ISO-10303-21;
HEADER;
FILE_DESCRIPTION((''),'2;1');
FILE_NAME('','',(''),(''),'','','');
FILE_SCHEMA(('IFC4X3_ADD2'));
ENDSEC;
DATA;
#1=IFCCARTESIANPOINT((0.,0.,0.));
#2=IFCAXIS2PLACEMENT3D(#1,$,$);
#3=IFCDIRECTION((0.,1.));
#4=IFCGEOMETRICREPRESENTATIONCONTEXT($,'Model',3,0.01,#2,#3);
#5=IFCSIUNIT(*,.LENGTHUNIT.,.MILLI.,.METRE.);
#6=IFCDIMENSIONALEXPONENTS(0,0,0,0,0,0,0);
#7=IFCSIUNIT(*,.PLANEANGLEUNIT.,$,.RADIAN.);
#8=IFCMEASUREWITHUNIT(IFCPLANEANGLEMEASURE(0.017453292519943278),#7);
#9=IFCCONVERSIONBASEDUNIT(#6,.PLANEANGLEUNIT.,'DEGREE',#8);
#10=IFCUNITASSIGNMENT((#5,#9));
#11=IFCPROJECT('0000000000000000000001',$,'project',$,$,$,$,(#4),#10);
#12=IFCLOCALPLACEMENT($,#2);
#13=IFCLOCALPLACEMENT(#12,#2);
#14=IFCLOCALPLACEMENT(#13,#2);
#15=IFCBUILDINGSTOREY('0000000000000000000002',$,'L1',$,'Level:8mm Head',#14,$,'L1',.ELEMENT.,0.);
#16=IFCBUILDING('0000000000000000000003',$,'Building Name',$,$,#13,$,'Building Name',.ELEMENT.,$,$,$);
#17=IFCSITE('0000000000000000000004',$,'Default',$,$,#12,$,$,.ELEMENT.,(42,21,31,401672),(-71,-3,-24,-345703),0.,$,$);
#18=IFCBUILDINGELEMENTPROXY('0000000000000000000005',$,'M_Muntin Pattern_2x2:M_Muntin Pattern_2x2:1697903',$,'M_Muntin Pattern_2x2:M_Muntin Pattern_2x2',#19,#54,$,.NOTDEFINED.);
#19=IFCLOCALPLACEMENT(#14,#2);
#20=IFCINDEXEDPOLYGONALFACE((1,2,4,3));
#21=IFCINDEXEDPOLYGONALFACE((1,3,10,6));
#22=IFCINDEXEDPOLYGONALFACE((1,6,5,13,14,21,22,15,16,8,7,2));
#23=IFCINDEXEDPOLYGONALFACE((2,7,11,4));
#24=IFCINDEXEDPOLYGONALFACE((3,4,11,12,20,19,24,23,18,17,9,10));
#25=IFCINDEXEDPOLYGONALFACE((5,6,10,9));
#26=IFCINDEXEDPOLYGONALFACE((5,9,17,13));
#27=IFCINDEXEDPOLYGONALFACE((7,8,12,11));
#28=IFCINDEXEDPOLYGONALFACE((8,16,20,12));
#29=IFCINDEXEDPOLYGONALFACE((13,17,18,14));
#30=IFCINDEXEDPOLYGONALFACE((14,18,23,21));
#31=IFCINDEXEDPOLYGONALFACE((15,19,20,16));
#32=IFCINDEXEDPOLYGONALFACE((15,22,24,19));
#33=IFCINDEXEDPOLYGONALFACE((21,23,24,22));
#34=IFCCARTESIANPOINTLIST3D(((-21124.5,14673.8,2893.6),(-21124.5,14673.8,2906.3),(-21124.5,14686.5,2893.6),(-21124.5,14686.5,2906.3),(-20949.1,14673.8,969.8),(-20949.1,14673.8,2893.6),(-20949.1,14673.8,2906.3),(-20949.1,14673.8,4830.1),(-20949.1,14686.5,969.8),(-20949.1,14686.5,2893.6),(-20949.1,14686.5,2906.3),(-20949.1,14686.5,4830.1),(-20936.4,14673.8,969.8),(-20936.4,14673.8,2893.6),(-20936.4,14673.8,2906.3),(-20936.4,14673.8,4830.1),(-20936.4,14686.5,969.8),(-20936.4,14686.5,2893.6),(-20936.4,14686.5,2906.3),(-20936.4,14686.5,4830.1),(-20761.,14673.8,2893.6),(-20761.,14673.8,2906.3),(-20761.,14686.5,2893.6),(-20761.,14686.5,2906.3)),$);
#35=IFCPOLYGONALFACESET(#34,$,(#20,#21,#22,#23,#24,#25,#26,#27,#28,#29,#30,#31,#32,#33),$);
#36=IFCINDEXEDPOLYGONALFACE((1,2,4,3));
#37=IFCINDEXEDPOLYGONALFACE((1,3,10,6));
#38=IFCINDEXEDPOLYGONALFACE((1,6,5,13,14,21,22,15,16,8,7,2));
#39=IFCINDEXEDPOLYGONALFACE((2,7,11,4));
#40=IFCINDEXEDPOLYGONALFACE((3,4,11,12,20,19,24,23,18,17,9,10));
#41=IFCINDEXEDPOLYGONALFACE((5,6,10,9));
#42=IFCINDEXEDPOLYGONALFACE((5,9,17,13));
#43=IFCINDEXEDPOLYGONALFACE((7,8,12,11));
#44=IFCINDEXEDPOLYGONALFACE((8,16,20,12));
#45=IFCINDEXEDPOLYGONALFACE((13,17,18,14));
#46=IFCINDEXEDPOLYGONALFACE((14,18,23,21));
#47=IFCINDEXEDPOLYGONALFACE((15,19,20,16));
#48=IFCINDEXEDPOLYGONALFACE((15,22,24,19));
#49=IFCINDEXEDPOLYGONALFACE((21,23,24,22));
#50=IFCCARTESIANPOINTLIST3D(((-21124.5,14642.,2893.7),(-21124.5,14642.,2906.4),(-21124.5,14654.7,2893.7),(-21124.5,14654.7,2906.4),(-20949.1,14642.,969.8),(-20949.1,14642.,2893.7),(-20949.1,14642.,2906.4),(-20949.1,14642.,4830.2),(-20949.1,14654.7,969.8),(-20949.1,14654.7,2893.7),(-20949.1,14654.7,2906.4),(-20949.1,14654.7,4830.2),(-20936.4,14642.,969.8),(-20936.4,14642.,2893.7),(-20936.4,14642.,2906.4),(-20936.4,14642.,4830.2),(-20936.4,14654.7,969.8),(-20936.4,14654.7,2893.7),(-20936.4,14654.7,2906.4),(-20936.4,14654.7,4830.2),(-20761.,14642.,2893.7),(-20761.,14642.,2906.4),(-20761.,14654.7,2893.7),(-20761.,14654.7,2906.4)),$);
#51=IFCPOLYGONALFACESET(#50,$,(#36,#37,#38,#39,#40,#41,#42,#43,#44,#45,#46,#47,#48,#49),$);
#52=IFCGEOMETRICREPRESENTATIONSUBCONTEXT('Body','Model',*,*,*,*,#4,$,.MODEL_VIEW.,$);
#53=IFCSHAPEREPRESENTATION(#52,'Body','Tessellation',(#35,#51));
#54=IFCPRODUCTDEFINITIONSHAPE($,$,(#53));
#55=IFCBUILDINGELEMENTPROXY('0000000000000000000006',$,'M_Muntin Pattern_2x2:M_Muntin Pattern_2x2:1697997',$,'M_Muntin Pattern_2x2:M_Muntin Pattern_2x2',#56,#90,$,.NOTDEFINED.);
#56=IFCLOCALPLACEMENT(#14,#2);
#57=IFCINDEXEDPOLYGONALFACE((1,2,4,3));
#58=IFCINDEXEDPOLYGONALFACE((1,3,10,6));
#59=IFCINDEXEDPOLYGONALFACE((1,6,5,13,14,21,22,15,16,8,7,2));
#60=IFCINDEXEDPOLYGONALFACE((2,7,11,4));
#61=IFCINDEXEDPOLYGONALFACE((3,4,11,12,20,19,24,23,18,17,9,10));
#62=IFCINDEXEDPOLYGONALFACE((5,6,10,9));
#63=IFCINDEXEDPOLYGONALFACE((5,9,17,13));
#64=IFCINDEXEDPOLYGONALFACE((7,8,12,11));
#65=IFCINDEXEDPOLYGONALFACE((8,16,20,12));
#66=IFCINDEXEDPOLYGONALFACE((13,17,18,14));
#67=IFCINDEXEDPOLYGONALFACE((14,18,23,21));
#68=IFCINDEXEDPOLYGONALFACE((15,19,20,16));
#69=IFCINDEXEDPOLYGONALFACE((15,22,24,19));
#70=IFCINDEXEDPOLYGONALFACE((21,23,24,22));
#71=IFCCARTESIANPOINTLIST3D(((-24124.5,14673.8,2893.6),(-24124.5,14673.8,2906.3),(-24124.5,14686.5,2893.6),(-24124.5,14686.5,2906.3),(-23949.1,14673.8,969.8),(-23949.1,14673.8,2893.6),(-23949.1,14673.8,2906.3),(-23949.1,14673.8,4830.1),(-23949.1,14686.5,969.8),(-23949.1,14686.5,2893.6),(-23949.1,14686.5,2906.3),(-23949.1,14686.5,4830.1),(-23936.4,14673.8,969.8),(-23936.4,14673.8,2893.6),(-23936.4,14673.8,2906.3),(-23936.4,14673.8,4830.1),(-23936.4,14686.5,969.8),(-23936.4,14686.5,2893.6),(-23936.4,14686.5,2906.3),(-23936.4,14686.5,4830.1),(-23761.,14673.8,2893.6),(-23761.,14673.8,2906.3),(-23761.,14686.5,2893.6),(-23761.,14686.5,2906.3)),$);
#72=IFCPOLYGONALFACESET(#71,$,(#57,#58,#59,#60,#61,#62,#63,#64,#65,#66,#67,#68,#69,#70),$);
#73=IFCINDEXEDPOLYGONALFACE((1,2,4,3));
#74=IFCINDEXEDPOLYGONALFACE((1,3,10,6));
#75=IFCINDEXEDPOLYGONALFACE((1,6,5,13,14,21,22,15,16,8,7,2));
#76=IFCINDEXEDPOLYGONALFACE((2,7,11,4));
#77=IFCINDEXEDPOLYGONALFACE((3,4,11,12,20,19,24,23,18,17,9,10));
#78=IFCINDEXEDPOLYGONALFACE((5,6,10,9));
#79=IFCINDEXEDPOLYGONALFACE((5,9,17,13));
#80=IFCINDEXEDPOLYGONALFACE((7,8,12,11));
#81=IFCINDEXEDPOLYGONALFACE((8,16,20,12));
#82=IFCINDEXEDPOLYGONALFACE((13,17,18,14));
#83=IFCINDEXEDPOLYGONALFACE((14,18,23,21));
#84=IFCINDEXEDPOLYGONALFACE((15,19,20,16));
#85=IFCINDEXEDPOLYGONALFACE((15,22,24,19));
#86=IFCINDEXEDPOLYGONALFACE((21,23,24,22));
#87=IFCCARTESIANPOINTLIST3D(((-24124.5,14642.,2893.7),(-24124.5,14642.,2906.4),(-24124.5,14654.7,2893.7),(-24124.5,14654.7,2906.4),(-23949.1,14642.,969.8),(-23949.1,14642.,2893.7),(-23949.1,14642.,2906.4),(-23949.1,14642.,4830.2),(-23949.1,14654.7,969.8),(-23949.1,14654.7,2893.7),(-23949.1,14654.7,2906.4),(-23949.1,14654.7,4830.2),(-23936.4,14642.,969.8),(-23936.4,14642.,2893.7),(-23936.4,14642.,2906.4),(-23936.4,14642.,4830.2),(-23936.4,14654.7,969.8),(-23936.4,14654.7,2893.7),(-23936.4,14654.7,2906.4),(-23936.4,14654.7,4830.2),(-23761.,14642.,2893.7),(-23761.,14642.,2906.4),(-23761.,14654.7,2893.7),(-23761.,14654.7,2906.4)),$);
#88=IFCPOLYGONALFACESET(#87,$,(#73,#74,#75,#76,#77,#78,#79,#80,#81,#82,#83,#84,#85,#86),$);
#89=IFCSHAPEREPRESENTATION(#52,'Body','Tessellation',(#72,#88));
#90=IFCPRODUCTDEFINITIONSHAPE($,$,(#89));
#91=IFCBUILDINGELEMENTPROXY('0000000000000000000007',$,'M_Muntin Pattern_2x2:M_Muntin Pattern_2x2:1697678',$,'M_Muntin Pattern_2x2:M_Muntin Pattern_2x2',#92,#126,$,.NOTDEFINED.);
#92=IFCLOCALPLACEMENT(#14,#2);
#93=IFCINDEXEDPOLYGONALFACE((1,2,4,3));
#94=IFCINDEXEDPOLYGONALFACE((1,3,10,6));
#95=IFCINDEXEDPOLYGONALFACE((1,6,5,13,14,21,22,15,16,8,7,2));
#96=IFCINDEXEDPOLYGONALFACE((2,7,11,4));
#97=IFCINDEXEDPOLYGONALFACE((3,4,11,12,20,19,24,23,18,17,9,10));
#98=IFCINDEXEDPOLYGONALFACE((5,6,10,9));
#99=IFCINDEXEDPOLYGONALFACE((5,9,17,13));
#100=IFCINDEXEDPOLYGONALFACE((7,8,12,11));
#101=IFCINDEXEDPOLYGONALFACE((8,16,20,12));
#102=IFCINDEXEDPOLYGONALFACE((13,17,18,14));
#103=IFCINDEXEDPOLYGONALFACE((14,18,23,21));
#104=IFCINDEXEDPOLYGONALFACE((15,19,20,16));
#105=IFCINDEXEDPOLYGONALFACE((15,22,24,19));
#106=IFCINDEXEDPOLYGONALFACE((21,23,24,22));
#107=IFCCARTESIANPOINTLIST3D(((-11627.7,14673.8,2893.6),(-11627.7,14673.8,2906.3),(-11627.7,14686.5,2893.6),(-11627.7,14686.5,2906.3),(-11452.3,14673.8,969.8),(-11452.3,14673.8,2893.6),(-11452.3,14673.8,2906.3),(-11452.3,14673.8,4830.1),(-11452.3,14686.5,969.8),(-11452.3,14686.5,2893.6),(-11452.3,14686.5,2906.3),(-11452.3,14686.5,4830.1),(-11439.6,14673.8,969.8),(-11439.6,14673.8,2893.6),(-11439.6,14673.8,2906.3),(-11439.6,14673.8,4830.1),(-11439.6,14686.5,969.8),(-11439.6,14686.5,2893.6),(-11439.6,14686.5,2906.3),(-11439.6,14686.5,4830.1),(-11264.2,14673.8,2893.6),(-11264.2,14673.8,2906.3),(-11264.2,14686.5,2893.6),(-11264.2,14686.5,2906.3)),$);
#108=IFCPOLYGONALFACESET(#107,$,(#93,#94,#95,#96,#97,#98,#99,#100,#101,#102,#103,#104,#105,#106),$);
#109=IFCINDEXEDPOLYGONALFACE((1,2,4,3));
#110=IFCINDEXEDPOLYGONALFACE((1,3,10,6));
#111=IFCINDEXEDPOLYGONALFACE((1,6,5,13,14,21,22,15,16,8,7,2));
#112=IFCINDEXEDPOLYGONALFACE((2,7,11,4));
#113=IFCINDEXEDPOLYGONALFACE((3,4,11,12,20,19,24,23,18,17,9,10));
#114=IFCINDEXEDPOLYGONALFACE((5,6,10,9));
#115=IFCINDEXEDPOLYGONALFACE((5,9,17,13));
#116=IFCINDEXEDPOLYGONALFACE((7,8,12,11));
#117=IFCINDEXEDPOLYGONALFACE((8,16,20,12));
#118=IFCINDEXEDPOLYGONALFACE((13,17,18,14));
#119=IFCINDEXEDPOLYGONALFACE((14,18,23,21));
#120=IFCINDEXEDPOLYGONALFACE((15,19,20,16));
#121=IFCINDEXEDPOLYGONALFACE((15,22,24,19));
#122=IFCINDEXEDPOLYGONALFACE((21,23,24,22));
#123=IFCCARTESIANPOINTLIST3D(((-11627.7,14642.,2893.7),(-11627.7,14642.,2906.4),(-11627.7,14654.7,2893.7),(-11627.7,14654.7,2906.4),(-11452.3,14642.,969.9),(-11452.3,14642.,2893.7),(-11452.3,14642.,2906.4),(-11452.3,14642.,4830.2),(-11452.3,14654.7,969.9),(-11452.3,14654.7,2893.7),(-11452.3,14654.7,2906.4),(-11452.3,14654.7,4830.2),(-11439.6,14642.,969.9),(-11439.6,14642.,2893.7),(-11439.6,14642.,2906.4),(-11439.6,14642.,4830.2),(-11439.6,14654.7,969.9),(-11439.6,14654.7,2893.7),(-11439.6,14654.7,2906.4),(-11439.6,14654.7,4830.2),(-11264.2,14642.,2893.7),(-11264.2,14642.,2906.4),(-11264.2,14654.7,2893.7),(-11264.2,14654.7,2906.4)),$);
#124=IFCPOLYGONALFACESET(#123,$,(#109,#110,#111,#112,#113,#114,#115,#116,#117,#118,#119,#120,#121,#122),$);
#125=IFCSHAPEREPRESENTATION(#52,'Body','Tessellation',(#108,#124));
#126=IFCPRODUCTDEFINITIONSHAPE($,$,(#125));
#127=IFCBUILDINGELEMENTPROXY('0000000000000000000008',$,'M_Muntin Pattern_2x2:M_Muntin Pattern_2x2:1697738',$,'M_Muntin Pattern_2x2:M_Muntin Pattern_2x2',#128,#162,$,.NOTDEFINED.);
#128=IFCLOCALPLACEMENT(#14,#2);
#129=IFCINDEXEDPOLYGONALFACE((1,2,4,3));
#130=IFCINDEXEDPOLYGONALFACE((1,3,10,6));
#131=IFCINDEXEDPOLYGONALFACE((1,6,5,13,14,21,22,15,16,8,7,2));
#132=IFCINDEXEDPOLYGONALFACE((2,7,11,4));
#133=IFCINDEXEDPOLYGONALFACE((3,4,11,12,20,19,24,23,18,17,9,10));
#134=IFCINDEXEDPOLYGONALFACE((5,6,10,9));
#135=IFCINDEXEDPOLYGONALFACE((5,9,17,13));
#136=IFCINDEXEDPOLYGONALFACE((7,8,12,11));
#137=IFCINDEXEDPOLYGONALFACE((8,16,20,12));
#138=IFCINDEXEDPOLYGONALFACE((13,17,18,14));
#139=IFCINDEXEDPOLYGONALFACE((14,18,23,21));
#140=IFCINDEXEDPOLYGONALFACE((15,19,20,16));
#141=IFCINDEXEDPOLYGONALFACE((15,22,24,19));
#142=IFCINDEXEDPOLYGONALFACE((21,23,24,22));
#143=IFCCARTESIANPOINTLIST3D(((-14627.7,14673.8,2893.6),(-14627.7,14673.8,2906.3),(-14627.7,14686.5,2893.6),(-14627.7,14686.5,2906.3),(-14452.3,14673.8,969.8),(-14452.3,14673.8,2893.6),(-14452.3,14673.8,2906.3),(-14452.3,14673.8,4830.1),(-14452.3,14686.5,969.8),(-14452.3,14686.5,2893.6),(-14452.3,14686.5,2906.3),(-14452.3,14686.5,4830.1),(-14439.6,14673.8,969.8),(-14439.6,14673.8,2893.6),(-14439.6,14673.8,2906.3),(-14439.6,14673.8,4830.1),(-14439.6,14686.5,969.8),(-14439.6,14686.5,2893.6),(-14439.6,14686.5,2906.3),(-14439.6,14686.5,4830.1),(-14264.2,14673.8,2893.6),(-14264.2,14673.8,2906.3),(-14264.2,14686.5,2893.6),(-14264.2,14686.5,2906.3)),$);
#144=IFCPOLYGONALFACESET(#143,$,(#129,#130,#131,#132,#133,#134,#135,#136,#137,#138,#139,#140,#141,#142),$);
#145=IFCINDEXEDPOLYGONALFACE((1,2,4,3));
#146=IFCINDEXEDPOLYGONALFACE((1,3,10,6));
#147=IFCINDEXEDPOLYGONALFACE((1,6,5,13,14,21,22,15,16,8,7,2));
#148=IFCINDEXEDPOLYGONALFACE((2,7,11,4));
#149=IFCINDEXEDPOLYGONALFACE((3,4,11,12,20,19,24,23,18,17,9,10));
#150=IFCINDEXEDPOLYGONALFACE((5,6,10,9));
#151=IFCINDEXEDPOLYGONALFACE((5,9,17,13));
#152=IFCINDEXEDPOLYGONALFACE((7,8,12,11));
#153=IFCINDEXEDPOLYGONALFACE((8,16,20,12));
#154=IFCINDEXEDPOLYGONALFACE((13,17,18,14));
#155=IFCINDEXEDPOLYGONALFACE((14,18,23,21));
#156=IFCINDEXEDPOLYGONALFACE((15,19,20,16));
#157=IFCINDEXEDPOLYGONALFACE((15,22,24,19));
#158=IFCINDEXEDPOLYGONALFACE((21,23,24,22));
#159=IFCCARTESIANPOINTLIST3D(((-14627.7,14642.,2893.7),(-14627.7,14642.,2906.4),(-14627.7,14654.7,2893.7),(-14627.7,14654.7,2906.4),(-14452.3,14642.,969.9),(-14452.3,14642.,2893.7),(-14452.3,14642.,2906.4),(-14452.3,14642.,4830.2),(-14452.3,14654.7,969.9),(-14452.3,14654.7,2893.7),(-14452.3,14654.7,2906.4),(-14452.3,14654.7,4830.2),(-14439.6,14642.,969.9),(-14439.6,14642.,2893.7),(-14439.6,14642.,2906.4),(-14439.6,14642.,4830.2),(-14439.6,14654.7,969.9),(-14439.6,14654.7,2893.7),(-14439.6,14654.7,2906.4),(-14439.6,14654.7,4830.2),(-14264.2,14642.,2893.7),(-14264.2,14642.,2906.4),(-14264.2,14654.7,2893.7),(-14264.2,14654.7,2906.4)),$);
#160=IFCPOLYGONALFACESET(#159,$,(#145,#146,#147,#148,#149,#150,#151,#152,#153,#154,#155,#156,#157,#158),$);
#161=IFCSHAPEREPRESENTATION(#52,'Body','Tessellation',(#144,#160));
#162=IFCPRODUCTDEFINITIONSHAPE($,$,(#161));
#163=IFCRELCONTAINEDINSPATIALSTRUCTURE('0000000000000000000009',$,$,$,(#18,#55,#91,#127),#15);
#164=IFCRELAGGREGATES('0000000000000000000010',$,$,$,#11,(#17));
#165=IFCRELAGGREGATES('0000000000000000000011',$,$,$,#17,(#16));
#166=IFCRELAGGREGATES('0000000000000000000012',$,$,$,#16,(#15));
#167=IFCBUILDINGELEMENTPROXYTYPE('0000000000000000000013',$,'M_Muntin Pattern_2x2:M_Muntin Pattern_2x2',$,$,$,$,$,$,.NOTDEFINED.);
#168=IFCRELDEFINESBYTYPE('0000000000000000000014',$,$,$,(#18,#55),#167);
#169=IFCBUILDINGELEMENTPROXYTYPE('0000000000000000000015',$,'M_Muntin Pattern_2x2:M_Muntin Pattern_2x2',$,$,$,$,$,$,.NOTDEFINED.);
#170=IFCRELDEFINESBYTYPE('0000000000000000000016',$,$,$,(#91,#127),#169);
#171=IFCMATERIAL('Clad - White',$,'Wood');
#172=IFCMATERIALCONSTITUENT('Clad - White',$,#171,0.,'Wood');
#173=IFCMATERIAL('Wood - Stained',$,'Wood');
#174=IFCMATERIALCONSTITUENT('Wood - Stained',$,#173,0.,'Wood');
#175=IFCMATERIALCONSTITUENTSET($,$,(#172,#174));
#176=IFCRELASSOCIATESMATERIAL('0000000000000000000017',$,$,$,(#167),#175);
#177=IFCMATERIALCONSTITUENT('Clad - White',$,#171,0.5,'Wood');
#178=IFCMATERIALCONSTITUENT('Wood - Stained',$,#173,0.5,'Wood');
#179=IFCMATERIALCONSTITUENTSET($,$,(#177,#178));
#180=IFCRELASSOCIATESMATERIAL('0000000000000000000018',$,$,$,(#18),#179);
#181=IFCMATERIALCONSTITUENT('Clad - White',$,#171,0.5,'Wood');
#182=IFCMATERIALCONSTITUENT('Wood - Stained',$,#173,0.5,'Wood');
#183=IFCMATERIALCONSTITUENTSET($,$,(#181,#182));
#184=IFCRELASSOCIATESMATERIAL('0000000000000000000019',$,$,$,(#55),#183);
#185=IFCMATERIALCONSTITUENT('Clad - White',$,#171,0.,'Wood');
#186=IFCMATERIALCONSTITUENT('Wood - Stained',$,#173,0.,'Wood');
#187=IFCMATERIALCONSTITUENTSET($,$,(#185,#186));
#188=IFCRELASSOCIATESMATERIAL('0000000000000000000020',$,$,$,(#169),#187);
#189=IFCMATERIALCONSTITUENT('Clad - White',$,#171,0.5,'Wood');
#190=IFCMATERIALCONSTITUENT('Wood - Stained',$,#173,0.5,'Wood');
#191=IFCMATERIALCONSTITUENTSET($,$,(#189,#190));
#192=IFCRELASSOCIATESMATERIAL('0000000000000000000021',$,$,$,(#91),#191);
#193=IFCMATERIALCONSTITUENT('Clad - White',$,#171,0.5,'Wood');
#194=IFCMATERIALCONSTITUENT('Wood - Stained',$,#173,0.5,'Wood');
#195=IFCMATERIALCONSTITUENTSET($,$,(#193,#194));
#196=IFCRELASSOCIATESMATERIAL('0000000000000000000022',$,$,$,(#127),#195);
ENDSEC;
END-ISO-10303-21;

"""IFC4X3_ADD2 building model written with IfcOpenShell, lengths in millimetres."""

from ifc_helpers import new_model, entity, si_unit, converted_unit, direction, frame, origin, place, context, subcontext, project, spatial, polyline, outline, extrude, source, transform, mapped, material, constituent, constituent_set, type_object, type_shapes, element, save


model = new_model("IFC4X3_ADD2")

# Units and contexts
model_context = context("Model", 3, precision=0.01, world=origin(), true_north=direction((0.0, 1.0)))
body_context = subcontext(model_context, "Body", "Model", "MODEL_VIEW")
ifc_project = project(units=[si_unit("LENGTHUNIT", "METRE", prefix="MILLI"), converted_unit("PLANEANGLEUNIT", "DEGREE", entity("IfcPlaneAngleMeasure", 0.017453292519943278), si_unit("PLANEANGLEUNIT", "RADIAN"), dimensions=[0, 0, 0, 0, 0, 0, 0])], contexts=[model_context])

# Site, building, storey
site_placement = place(None, origin())
site = spatial("IfcSite", under=ifc_project, at=site_placement, Name="Default", CompositionType="ELEMENT", RefLatitude=(42, 21, 31, 401672), RefLongitude=(-71, -3, -24, -345703), RefElevation=0.0)
building_placement = place(site_placement, origin())
building = spatial("IfcBuilding", under=site, at=building_placement, Name="Building Name", LongName="Building Name", CompositionType="ELEMENT")
storey_placement = place(building_placement, origin())
storey = spatial("IfcBuildingStorey", under=building, at=storey_placement, Name="L1", ObjectType="Level:8mm Head", LongName="L1", CompositionType="ELEMENT", Elevation=0.0)

# Building element proxies
ifc_material_1 = material(Name="Clad - White", Category="Wood")
ifc_material_2 = material(Name="Wood - Stained", Category="Wood")
ifc_constituent_1 = constituent(ifc_material_1, Name="Clad - White", Category="Wood", fraction=0.0)
ifc_constituent_2 = constituent(ifc_material_2, Name="Wood - Stained", Category="Wood", fraction=0.0)
ifc_constituent_set_1 = constituent_set(constituents=[ifc_constituent_1, ifc_constituent_2])
building_element_proxy_type_1 = type_object("IfcBuildingElementProxyType", Name="M_Muntin Pattern_2x2:M_Muntin Pattern_2x2", PredefinedType="NOTDEFINED", material=ifc_constituent_set_1)
shared_shape_1 = source(origin(), body_context, "Body", "SweptSolid", [
    extrude(outline(polyline([(6.4, -6.4), (1930.1, -6.4), (1930.1, 6.3), (6.4, 6.3), (6.4, 181.7), (-6.3, 181.7), (-6.3, 6.3), (-1930.2, 6.3), (-1930.2, -6.4), (-6.3, -6.4), (-6.3, -181.7), (6.4, -181.7), (6.4, -6.4)])), frame((0.0, 9.5, 1930.1), z_axis=(0.0, 1.0, 0.0), x_axis=(0.0, 0.0, 1.0)), (0.0, 0.0, 1.0), 12.7),
    extrude(outline(polyline([(6.4, -6.4), (1930.2, -6.4), (1930.2, 6.3), (6.4, 6.3), (6.4, 181.7), (-6.3, 181.7), (-6.3, 6.3), (-1930.2, 6.3), (-1930.2, -6.4), (-6.3, -6.4), (-6.3, -181.7), (6.4, -181.7), (6.4, -6.4)])), frame((0.0, -22.2, 1930.2), z_axis=(0.0, 1.0, 0.0), x_axis=(0.0, 0.0, 1.0)), (0.0, 0.0, 1.0), 12.7),
])
type_shapes(building_element_proxy_type_1, [shared_shape_1])
ifc_constituent_3 = constituent(ifc_material_1, Name="Clad - White", Category="Wood", fraction=0.5)
ifc_constituent_4 = constituent(ifc_material_2, Name="Wood - Stained", Category="Wood", fraction=0.5)
ifc_constituent_set_2 = constituent_set(constituents=[ifc_constituent_3, ifc_constituent_4])
proxy_1_placement = place(storey_placement, frame((-20942.8, 14664.3, 969.8)))
element("IfcBuildingElementProxy", 1, at=proxy_1_placement, inside=storey, type_object=building_element_proxy_type_1, material=ifc_constituent_set_2, Name="M_Muntin Pattern_2x2:M_Muntin Pattern_2x2:1697903", ObjectType="M_Muntin Pattern_2x2:M_Muntin Pattern_2x2", PredefinedType="NOTDEFINED", context=body_context, shape_type="MappedRepresentation", body=[
    mapped(shared_shape_1, transform((0.0, 0.0, 0.0), scale=1.0)),
])
ifc_constituent_5 = constituent(ifc_material_1, Name="Clad - White", Category="Wood", fraction=0.5)
ifc_constituent_6 = constituent(ifc_material_2, Name="Wood - Stained", Category="Wood", fraction=0.5)
ifc_constituent_set_3 = constituent_set(constituents=[ifc_constituent_5, ifc_constituent_6])
proxy_2_placement = place(storey_placement, frame((-23942.8, 14664.3, 969.8)))
element("IfcBuildingElementProxy", 2, at=proxy_2_placement, inside=storey, type_object=building_element_proxy_type_1, material=ifc_constituent_set_3, Name="M_Muntin Pattern_2x2:M_Muntin Pattern_2x2:1697997", ObjectType="M_Muntin Pattern_2x2:M_Muntin Pattern_2x2", PredefinedType="NOTDEFINED", context=body_context, shape_type="MappedRepresentation", body=[
    mapped(shared_shape_1, transform((0.0, 0.0, 0.0), scale=1.0)),
])
ifc_constituent_7 = constituent(ifc_material_1, Name="Clad - White", Category="Wood", fraction=0.5)
ifc_constituent_8 = constituent(ifc_material_2, Name="Wood - Stained", Category="Wood", fraction=0.5)
ifc_constituent_set_4 = constituent_set(constituents=[ifc_constituent_7, ifc_constituent_8])
ifc_constituent_9 = constituent(ifc_material_1, Name="Clad - White", Category="Wood", fraction=0.0)
ifc_constituent_10 = constituent(ifc_material_2, Name="Wood - Stained", Category="Wood", fraction=0.0)
ifc_constituent_set_5 = constituent_set(constituents=[ifc_constituent_9, ifc_constituent_10])
building_element_proxy_type_2 = type_object("IfcBuildingElementProxyType", Name="M_Muntin Pattern_2x2:M_Muntin Pattern_2x2", PredefinedType="NOTDEFINED", material=ifc_constituent_set_5)
shared_shape_2 = source(origin(), body_context, "Body", "SweptSolid", [
    extrude(outline(polyline([(6.4, -6.4), (1930.1, -6.4), (1930.1, 6.3), (6.4, 6.3), (6.4, 181.7), (-6.3, 181.7), (-6.3, 6.3), (-1930.2, 6.3), (-1930.2, -6.4), (-6.3, -6.4), (-6.3, -181.7), (6.4, -181.7), (6.4, -6.4)])), frame((0.0, -22.2, 1930.1), z_axis=(0.0, 1.0, 0.0), x_axis=(0.0, 0.0, 1.0)), (0.0, 0.0, 1.0), 12.7),
    extrude(outline(polyline([(6.4, -6.4), (1930.2, -6.4), (1930.2, 6.3), (6.4, 6.3), (6.4, 181.7), (-6.3, 181.7), (-6.3, 6.3), (-1930.2, 6.3), (-1930.2, -6.4), (-6.3, -6.4), (-6.3, -181.7), (6.4, -181.7), (6.4, -6.4)])), frame((0.0, 9.5, 1930.2), z_axis=(0.0, 1.0, 0.0), x_axis=(0.0, 0.0, 1.0)), (0.0, 0.0, 1.0), 12.7),
])
type_shapes(building_element_proxy_type_2, [shared_shape_2])
proxy_3_placement = place(storey_placement, frame((-11445.9, 14664.3, 969.9), z_axis=(0.0, 0.0, 1.0), x_axis=(-1.0, 0.0, 0.0)))
element("IfcBuildingElementProxy", 3, at=proxy_3_placement, inside=storey, type_object=building_element_proxy_type_2, material=ifc_constituent_set_4, Name="M_Muntin Pattern_2x2:M_Muntin Pattern_2x2:1697678", ObjectType="M_Muntin Pattern_2x2:M_Muntin Pattern_2x2", PredefinedType="NOTDEFINED", context=body_context, shape_type="MappedRepresentation", body=[
    mapped(shared_shape_2, transform((0.0, 0.0, 0.0), scale=1.0)),
])
ifc_constituent_11 = constituent(ifc_material_1, Name="Clad - White", Category="Wood", fraction=0.5)
ifc_constituent_12 = constituent(ifc_material_2, Name="Wood - Stained", Category="Wood", fraction=0.5)
ifc_constituent_set_6 = constituent_set(constituents=[ifc_constituent_11, ifc_constituent_12])
proxy_4_placement = place(storey_placement, frame((-14445.9, 14664.3, 969.9), z_axis=(0.0, 0.0, 1.0), x_axis=(-1.0, 0.0, 0.0)))
element("IfcBuildingElementProxy", 4, at=proxy_4_placement, inside=storey, type_object=building_element_proxy_type_2, material=ifc_constituent_set_6, Name="M_Muntin Pattern_2x2:M_Muntin Pattern_2x2:1697738", ObjectType="M_Muntin Pattern_2x2:M_Muntin Pattern_2x2", PredefinedType="NOTDEFINED", context=body_context, shape_type="MappedRepresentation", body=[
    mapped(shared_shape_2, transform((0.0, 0.0, 0.0), scale=1.0)),
])

save(model, "model.ifc")
